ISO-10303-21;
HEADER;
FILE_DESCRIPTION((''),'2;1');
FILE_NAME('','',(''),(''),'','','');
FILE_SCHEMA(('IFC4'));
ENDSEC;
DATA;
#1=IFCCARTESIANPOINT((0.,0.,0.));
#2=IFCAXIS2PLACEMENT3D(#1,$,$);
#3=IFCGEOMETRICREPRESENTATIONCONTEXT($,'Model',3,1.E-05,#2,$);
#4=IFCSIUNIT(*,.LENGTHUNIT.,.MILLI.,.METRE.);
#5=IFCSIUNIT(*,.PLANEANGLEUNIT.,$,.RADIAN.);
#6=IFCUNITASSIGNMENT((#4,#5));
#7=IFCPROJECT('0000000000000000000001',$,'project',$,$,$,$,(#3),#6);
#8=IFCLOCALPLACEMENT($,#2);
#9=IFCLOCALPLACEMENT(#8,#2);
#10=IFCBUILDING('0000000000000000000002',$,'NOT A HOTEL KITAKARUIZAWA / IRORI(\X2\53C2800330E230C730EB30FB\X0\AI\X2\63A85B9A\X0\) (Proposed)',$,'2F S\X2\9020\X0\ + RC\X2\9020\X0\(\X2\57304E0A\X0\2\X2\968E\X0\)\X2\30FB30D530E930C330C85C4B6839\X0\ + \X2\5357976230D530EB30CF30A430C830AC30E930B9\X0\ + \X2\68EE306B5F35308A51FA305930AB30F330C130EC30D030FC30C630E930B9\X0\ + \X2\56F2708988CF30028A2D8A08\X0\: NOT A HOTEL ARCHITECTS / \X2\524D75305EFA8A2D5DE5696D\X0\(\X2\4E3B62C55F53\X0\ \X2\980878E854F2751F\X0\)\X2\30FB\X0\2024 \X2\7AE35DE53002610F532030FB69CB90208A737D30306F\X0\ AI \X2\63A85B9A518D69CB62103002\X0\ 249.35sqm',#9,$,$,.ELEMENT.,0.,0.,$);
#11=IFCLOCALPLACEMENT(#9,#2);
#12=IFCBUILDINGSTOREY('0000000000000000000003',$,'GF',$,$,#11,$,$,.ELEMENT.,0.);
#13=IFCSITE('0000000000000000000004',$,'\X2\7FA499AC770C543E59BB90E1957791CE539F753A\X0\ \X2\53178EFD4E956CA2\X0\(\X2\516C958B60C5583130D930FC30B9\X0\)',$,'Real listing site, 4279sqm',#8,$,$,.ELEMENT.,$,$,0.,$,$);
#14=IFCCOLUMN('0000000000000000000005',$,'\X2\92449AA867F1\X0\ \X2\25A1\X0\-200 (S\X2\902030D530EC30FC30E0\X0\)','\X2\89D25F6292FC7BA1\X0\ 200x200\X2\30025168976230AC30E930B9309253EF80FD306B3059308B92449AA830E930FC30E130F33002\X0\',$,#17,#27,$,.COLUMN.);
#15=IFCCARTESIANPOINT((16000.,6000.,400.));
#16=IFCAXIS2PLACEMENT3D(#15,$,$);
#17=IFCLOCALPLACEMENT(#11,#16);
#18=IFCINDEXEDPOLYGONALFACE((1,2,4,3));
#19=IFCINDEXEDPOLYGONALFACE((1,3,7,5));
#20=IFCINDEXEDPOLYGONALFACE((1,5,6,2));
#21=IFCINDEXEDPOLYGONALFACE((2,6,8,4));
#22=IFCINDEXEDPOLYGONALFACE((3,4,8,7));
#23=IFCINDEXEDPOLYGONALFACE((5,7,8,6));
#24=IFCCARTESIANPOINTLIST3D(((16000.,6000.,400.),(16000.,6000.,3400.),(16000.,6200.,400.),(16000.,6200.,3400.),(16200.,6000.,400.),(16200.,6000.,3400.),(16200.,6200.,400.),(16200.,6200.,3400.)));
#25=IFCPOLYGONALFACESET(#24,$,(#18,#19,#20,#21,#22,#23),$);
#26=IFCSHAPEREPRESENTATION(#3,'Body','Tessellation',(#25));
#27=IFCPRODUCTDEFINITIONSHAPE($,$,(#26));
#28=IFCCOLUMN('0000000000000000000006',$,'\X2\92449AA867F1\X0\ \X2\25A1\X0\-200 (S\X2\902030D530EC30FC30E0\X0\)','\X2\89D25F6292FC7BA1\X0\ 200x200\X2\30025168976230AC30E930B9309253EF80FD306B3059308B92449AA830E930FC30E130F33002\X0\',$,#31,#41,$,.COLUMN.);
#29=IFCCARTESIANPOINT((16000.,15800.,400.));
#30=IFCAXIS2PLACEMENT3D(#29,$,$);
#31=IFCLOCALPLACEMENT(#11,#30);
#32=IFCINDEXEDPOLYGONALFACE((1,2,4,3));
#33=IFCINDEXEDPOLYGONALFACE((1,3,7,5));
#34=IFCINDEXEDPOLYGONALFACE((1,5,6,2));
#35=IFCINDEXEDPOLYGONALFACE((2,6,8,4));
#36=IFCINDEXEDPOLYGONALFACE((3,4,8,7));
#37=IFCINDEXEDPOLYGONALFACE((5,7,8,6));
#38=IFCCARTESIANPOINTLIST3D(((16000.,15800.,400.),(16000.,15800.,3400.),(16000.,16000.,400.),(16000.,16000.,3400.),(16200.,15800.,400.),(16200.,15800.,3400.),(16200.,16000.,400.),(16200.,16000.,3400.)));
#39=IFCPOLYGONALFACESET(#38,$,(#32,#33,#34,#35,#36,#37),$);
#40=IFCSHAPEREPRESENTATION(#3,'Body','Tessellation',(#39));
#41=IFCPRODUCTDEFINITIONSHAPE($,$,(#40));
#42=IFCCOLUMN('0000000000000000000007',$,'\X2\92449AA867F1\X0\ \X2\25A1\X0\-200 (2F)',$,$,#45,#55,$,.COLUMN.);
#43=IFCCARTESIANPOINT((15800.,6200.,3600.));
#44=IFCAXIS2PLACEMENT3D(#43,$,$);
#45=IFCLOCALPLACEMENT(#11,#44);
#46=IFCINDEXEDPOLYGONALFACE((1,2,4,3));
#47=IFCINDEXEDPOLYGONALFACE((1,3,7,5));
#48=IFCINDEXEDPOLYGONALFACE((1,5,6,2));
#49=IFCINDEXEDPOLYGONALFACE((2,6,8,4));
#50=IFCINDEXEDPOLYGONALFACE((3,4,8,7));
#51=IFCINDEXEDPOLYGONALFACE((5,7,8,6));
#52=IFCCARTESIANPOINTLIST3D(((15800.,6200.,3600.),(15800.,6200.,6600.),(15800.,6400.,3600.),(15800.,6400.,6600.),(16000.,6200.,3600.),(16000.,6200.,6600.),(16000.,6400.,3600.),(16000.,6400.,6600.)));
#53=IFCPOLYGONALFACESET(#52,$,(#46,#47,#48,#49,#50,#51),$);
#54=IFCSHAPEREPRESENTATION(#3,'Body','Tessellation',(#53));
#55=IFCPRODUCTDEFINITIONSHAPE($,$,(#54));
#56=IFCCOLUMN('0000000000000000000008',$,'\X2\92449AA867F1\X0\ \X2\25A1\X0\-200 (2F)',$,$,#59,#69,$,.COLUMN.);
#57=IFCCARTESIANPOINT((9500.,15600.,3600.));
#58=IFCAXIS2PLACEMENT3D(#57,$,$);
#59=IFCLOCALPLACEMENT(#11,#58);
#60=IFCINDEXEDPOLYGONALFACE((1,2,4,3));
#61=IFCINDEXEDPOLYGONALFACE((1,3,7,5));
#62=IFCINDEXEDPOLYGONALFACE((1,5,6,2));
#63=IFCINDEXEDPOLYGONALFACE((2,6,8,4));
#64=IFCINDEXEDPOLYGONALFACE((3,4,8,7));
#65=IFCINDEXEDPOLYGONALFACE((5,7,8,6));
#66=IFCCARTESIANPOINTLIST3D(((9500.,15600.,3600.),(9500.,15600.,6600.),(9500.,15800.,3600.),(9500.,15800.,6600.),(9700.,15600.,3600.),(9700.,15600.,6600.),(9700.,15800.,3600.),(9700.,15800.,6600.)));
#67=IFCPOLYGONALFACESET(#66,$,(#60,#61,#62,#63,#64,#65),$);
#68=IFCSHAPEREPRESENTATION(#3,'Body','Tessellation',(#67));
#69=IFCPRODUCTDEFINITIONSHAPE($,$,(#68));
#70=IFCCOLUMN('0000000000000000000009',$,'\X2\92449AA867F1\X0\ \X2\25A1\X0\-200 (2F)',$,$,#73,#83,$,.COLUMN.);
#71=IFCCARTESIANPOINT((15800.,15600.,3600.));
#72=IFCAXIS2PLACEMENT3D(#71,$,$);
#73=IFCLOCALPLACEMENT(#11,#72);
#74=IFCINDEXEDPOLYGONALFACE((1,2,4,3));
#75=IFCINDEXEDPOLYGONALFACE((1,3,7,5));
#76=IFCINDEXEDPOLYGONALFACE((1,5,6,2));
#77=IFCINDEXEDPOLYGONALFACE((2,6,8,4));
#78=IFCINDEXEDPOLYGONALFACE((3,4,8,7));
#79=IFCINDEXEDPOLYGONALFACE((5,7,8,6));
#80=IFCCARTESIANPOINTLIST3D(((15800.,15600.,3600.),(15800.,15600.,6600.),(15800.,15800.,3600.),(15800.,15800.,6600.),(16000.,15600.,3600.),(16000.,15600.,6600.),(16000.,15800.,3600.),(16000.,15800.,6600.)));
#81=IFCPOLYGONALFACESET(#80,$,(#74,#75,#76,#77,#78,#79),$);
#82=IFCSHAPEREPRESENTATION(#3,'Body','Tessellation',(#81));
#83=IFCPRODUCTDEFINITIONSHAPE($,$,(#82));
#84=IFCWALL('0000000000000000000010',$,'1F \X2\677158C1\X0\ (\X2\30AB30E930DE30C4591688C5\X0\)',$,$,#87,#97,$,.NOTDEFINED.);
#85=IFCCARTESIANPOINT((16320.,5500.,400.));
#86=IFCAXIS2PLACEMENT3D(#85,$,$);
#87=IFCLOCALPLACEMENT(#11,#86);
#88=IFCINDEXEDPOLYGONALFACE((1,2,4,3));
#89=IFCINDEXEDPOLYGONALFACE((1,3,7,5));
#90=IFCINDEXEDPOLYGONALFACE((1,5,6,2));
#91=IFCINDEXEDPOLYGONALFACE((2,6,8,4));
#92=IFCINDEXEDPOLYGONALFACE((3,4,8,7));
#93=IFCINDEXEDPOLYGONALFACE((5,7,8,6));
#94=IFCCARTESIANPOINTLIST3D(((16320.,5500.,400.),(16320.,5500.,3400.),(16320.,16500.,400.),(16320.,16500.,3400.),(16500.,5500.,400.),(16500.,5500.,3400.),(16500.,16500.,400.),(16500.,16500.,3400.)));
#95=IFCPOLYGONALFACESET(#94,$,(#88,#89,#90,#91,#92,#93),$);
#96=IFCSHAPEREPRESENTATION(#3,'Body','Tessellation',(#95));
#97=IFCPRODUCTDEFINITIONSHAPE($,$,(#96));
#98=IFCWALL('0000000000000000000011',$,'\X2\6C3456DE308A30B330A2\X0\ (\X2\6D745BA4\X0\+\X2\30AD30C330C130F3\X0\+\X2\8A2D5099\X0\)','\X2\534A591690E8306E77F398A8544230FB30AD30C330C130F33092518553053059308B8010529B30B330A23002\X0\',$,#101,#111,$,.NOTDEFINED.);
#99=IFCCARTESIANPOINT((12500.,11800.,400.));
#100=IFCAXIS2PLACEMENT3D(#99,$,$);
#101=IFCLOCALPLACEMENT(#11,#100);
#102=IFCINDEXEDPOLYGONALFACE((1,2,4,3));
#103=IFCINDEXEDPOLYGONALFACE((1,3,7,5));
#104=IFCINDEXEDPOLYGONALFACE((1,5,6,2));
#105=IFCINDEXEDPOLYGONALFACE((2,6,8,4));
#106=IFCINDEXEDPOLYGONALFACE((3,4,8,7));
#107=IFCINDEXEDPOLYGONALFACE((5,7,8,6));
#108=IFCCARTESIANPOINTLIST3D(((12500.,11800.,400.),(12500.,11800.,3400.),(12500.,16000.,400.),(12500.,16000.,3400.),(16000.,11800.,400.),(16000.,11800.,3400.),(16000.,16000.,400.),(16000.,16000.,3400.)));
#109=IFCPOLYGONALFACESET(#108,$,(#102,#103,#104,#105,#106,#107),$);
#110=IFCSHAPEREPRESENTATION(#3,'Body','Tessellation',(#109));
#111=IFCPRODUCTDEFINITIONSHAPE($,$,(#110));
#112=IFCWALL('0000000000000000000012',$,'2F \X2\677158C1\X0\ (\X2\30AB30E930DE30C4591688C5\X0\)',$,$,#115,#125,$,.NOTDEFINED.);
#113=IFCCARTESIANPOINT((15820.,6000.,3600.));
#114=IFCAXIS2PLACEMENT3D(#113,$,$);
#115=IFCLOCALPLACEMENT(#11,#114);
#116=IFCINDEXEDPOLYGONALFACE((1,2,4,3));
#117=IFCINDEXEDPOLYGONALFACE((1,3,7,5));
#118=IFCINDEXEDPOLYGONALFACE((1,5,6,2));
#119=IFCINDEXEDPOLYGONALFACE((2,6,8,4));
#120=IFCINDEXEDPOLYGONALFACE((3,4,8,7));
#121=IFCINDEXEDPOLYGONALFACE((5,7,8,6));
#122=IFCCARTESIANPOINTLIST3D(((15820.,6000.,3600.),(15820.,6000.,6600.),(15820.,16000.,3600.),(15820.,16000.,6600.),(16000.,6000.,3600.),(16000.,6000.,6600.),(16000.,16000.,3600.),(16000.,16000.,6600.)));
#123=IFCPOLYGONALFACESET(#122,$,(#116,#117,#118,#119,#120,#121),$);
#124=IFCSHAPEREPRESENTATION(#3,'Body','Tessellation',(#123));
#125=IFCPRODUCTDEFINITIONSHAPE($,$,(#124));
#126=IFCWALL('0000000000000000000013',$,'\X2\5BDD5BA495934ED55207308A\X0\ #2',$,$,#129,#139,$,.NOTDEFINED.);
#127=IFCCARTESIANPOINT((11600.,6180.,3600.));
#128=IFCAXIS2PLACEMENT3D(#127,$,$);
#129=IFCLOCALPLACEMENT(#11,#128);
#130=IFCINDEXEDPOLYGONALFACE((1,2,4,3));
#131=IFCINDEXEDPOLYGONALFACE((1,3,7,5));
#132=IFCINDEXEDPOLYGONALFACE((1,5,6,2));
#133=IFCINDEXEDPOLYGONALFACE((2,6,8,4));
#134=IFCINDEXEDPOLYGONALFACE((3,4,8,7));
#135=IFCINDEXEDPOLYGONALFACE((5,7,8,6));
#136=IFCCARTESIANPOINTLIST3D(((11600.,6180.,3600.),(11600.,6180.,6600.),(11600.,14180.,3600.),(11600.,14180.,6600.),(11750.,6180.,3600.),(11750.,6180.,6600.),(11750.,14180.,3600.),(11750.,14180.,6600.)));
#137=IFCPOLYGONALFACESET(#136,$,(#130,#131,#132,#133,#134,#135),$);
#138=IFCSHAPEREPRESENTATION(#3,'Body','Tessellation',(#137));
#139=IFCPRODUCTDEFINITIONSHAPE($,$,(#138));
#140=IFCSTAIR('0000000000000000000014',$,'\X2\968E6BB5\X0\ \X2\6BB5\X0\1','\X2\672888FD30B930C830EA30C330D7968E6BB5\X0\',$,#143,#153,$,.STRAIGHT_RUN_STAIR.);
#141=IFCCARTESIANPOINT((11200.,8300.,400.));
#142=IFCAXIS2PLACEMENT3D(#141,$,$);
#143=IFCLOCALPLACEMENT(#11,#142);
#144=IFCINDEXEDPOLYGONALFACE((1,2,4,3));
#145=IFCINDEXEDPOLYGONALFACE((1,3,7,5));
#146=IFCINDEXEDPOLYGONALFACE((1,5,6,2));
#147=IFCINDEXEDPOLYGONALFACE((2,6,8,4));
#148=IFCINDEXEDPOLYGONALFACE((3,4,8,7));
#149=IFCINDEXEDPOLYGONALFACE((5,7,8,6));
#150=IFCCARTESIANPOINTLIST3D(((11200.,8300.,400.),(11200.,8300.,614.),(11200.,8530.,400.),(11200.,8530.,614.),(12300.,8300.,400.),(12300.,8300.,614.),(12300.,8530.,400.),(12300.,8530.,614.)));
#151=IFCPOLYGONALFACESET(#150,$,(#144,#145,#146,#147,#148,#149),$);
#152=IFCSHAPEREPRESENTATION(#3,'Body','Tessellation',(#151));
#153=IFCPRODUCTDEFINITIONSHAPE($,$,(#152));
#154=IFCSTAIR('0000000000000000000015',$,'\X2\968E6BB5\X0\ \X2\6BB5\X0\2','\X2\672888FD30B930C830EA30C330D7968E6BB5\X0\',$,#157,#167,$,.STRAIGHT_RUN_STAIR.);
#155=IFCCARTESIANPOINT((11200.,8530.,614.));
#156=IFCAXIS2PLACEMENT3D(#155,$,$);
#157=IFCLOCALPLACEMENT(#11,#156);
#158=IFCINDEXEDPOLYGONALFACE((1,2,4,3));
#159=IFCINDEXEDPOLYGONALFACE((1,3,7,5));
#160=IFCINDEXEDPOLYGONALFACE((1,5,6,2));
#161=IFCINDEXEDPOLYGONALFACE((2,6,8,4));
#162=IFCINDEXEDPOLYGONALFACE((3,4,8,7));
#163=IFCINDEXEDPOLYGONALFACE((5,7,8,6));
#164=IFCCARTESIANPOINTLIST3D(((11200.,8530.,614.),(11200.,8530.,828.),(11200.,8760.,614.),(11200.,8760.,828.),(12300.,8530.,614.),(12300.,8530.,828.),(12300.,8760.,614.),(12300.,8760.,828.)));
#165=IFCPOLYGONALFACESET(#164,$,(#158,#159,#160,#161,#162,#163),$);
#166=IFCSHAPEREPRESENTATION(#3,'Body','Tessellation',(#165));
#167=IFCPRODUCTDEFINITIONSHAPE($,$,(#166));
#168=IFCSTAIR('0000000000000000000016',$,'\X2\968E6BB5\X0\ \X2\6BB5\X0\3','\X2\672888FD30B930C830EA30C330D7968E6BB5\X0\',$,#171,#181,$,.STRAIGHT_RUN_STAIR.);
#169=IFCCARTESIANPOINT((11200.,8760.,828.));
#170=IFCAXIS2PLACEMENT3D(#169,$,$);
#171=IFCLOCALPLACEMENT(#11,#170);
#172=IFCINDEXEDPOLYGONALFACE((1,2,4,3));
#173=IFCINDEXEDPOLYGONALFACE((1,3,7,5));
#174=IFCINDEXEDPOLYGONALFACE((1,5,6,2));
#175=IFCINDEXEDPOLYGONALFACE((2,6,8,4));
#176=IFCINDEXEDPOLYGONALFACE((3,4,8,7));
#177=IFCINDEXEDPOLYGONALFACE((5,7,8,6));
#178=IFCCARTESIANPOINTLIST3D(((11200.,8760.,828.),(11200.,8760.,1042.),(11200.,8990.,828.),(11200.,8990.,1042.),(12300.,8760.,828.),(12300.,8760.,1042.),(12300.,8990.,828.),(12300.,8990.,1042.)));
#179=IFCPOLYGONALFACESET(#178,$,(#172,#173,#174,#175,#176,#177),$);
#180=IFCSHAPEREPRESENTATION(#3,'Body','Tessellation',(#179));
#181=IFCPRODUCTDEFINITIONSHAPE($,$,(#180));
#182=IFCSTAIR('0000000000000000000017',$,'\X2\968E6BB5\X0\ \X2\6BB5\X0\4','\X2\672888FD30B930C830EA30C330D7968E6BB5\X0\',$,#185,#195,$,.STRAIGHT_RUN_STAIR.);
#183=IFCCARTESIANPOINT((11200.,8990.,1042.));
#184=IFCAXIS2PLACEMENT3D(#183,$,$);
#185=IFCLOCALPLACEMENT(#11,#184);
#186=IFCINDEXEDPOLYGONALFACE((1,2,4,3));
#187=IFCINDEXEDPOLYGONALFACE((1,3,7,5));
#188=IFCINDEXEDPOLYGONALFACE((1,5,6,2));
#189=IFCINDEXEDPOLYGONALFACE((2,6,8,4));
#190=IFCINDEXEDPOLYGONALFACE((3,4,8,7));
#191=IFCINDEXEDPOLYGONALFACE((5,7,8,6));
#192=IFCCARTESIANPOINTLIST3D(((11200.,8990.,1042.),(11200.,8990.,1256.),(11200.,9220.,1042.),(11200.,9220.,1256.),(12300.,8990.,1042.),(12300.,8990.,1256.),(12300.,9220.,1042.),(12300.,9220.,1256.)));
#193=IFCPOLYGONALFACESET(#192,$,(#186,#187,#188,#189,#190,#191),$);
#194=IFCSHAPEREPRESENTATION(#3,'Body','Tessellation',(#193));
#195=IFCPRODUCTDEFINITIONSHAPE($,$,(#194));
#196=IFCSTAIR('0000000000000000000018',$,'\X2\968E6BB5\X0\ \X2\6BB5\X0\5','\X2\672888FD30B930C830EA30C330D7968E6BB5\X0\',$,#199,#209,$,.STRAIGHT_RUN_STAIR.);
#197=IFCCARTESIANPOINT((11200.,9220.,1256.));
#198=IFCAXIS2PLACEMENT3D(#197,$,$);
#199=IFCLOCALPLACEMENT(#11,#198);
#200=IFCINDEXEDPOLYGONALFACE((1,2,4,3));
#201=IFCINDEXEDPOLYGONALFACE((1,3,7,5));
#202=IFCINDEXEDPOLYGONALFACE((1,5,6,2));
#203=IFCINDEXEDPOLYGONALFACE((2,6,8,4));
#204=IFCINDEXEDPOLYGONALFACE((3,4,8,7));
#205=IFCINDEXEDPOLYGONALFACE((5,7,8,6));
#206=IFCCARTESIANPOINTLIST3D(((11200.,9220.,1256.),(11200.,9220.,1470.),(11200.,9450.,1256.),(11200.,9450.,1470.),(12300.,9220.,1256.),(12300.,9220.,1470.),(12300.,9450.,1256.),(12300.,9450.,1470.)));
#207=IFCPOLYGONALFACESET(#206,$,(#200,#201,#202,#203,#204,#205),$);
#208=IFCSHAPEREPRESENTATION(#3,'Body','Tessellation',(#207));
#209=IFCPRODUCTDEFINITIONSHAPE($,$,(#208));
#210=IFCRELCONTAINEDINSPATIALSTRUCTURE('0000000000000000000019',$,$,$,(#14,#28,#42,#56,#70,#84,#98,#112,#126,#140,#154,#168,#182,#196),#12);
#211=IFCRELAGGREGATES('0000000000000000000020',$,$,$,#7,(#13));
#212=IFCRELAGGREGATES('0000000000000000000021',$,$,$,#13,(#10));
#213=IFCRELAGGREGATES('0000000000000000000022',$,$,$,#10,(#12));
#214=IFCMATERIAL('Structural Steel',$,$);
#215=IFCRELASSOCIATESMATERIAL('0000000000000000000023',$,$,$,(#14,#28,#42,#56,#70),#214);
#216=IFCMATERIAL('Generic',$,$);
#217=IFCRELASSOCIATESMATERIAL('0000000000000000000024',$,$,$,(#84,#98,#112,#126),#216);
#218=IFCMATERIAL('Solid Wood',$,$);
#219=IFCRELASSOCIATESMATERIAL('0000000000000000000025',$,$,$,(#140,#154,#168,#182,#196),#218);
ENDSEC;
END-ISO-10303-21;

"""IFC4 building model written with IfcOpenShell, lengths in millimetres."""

from ifc_helpers import new_model, si_unit, frame, frame_2d, origin, place, context, project, spatial, rectangle, extrude, material, element, save


model = new_model("IFC4")

# Units and contexts
model_context = context("Model", 3, precision=1e-05, world=origin())
ifc_project = project(units=[si_unit("LENGTHUNIT", "METRE", prefix="MILLI"), si_unit("PLANEANGLEUNIT", "RADIAN")], contexts=[model_context])

# Site, building, storey
site_placement = place(None, origin())
site = spatial("IfcSite", under=ifc_project, at=site_placement, Name="群馬県吾妻郡長野原町 北軽井沢(公開情報ベース)", ObjectType="Real listing site, 4279sqm", CompositionType="ELEMENT", RefElevation=0.0)
building_placement = place(site_placement, origin())
building = spatial("IfcBuilding", under=site, at=building_placement, Name="NOT A HOTEL KITAKARUIZAWA / IRORI(参考モデル・AI推定) (Proposed)", ObjectType="2F S造 + RC造(地上2階)・フラット屋根 + 南面フルハイトガラス + 森に張り出すカンチレバーテラス + 囲炉裏。設計: NOT A HOTEL ARCHITECTS / 前田建設工業(主担当 須磨哲生)・2024 竣工。意匠・構造詳細は AI 推定再構成。 249.35sqm", CompositionType="ELEMENT", ElevationOfRefHeight=0.0, ElevationOfTerrain=0.0)
storey_placement = place(building_placement, origin())
storey = spatial("IfcBuildingStorey", under=building, at=storey_placement, Name="GF", CompositionType="ELEMENT", Elevation=0.0)

# Columns
ifc_material_1 = material(Name="Structural Steel")
column_1_placement = place(storey_placement, frame((16000.0, 6000.0, 400.0)))
element("IfcColumn", 1, at=column_1_placement, inside=storey, material=ifc_material_1, Name="鉄骨柱 □-200 (S造フレーム)", Description="角形鋼管 200x200。全面ガラスを可能にする鉄骨ラーメン。", PredefinedType="COLUMN", context=model_context, shape_type="SweptSolid", body=[
    extrude(rectangle(XDim=200.0, YDim=200.0, at=frame_2d((100.0, 100.0))), frame((16000.0, 6000.0, 400.0)), (0.0, 0.0, 1.0), 3000.0),
])
column_2_placement = place(storey_placement, frame((16000.0, 15800.0, 400.0)))
element("IfcColumn", 2, at=column_2_placement, inside=storey, material=ifc_material_1, Name="鉄骨柱 □-200 (S造フレーム)", Description="角形鋼管 200x200。全面ガラスを可能にする鉄骨ラーメン。", PredefinedType="COLUMN", context=model_context, shape_type="SweptSolid", body=[
    extrude(rectangle(XDim=200.0, YDim=200.0, at=frame_2d((100.0, 100.0))), frame((16000.0, 15800.0, 400.0)), (0.0, 0.0, 1.0), 3000.0),
])
column_3_placement = place(storey_placement, frame((15800.0, 6200.0, 3600.0)))
element("IfcColumn", 3, at=column_3_placement, inside=storey, material=ifc_material_1, Name="鉄骨柱 □-200 (2F)", PredefinedType="COLUMN", context=model_context, shape_type="SweptSolid", body=[
    extrude(rectangle(XDim=200.0, YDim=200.0, at=frame_2d((100.0, 100.0))), frame((15800.0, 6200.0, 3600.0)), (0.0, 0.0, 1.0), 3000.0),
])
column_4_placement = place(storey_placement, frame((9500.0, 15600.0, 3600.0)))
element("IfcColumn", 4, at=column_4_placement, inside=storey, material=ifc_material_1, Name="鉄骨柱 □-200 (2F)", PredefinedType="COLUMN", context=model_context, shape_type="SweptSolid", body=[
    extrude(rectangle(XDim=200.0, YDim=200.0, at=frame_2d((100.0, 100.0))), frame((9500.0, 15600.0, 3600.0)), (0.0, 0.0, 1.0), 3000.0),
])
column_5_placement = place(storey_placement, frame((15800.0, 15600.0, 3600.0)))
element("IfcColumn", 5, at=column_5_placement, inside=storey, material=ifc_material_1, Name="鉄骨柱 □-200 (2F)", PredefinedType="COLUMN", context=model_context, shape_type="SweptSolid", body=[
    extrude(rectangle(XDim=200.0, YDim=200.0, at=frame_2d((100.0, 100.0))), frame((15800.0, 15600.0, 3600.0)), (0.0, 0.0, 1.0), 3000.0),
])

# Walls
ifc_material_2 = material(Name="Generic")
wall_1_placement = place(storey_placement, frame((16320.0, 5500.0, 400.0)))
element("IfcWall", 6, at=wall_1_placement, inside=storey, material=ifc_material_2, Name="1F 東壁 (カラマツ外装)", PredefinedType="NOTDEFINED", context=model_context, shape_type="SweptSolid", body=[
    extrude(rectangle(XDim=180.0, YDim=11000.0, at=frame_2d((90.0, 5500.0))), frame((16320.0, 5500.0, 400.0)), (0.0, 0.0, 1.0), 3000.0),
])
wall_2_placement = place(storey_placement, frame((12500.0, 11800.0, 400.0)))
element("IfcWall", 7, at=wall_2_placement, inside=storey, material=ifc_material_2, Name="水回りコア (浴室+キッチン+設備)", Description="半外部の石風呂・キッチンを内包する耐力コア。", PredefinedType="NOTDEFINED", context=model_context, shape_type="SweptSolid", body=[
    extrude(rectangle(XDim=3500.0, YDim=4200.0, at=frame_2d((1750.0, 2100.0))), frame((12500.0, 11800.0, 400.0)), (0.0, 0.0, 1.0), 3000.0),
])
wall_3_placement = place(storey_placement, frame((15820.0, 6000.0, 3600.0)))
element("IfcWall", 8, at=wall_3_placement, inside=storey, material=ifc_material_2, Name="2F 東壁 (カラマツ外装)", PredefinedType="NOTDEFINED", context=model_context, shape_type="SweptSolid", body=[
    extrude(rectangle(XDim=180.0, YDim=10000.0, at=frame_2d((90.0, 5000.0))), frame((15820.0, 6000.0, 3600.0)), (0.0, 0.0, 1.0), 3000.0),
])
wall_4_placement = place(storey_placement, frame((11600.0, 6180.0, 3600.0)))
element("IfcWall", 9, at=wall_4_placement, inside=storey, material=ifc_material_2, Name="寝室間仕切り #2", PredefinedType="NOTDEFINED", context=model_context, shape_type="SweptSolid", body=[
    extrude(rectangle(XDim=150.0, YDim=8000.0, at=frame_2d((75.0, 4000.0))), frame((11600.0, 6180.0, 3600.0)), (0.0, 0.0, 1.0), 3000.0),
])

# Stairs
ifc_material_3 = material(Name="Solid Wood")
stair_1_placement = place(storey_placement, frame((11200.0, 8300.0, 400.0)))
element("IfcStair", 10, at=stair_1_placement, inside=storey, material=ifc_material_3, Name="階段 段1", Description="木製ストリップ階段", PredefinedType="STRAIGHT_RUN_STAIR", context=model_context, shape_type="SweptSolid", body=[
    extrude(rectangle(XDim=1100.0, YDim=230.0, at=frame_2d((550.0, 115.0))), frame((11200.0, 8300.0, 400.0)), (0.0, 0.0, 1.0), 214.0),
])
stair_2_placement = place(storey_placement, frame((11200.0, 8530.0, 614.0)))
element("IfcStair", 11, at=stair_2_placement, inside=storey, material=ifc_material_3, Name="階段 段2", Description="木製ストリップ階段", PredefinedType="STRAIGHT_RUN_STAIR", context=model_context, shape_type="SweptSolid", body=[
    extrude(rectangle(XDim=1100.0, YDim=230.0, at=frame_2d((550.0, 115.0))), frame((11200.0, 8530.0, 614.0)), (0.0, 0.0, 1.0), 214.0),
])
stair_3_placement = place(storey_placement, frame((11200.0, 8760.0, 828.0)))
element("IfcStair", 12, at=stair_3_placement, inside=storey, material=ifc_material_3, Name="階段 段3", Description="木製ストリップ階段", PredefinedType="STRAIGHT_RUN_STAIR", context=model_context, shape_type="SweptSolid", body=[
    extrude(rectangle(XDim=1100.0, YDim=230.0, at=frame_2d((550.0, 115.0))), frame((11200.0, 8760.0, 828.0)), (0.0, 0.0, 1.0), 214.0),
])
stair_4_placement = place(storey_placement, frame((11200.0, 8990.0, 1042.0)))
element("IfcStair", 13, at=stair_4_placement, inside=storey, material=ifc_material_3, Name="階段 段4", Description="木製ストリップ階段", PredefinedType="STRAIGHT_RUN_STAIR", context=model_context, shape_type="SweptSolid", body=[
    extrude(rectangle(XDim=1100.0, YDim=230.0, at=frame_2d((550.0, 115.0))), frame((11200.0, 8990.0, 1042.0)), (0.0, 0.0, 1.0), 214.0),
])
stair_5_placement = place(storey_placement, frame((11200.0, 9220.0, 1256.0)))
element("IfcStair", 14, at=stair_5_placement, inside=storey, material=ifc_material_3, Name="階段 段5", Description="木製ストリップ階段", PredefinedType="STRAIGHT_RUN_STAIR", context=model_context, shape_type="SweptSolid", body=[
    extrude(rectangle(XDim=1100.0, YDim=230.0, at=frame_2d((550.0, 115.0))), frame((11200.0, 9220.0, 1256.0)), (0.0, 0.0, 1.0), 214.0),
])

save(model, "model.ifc")
